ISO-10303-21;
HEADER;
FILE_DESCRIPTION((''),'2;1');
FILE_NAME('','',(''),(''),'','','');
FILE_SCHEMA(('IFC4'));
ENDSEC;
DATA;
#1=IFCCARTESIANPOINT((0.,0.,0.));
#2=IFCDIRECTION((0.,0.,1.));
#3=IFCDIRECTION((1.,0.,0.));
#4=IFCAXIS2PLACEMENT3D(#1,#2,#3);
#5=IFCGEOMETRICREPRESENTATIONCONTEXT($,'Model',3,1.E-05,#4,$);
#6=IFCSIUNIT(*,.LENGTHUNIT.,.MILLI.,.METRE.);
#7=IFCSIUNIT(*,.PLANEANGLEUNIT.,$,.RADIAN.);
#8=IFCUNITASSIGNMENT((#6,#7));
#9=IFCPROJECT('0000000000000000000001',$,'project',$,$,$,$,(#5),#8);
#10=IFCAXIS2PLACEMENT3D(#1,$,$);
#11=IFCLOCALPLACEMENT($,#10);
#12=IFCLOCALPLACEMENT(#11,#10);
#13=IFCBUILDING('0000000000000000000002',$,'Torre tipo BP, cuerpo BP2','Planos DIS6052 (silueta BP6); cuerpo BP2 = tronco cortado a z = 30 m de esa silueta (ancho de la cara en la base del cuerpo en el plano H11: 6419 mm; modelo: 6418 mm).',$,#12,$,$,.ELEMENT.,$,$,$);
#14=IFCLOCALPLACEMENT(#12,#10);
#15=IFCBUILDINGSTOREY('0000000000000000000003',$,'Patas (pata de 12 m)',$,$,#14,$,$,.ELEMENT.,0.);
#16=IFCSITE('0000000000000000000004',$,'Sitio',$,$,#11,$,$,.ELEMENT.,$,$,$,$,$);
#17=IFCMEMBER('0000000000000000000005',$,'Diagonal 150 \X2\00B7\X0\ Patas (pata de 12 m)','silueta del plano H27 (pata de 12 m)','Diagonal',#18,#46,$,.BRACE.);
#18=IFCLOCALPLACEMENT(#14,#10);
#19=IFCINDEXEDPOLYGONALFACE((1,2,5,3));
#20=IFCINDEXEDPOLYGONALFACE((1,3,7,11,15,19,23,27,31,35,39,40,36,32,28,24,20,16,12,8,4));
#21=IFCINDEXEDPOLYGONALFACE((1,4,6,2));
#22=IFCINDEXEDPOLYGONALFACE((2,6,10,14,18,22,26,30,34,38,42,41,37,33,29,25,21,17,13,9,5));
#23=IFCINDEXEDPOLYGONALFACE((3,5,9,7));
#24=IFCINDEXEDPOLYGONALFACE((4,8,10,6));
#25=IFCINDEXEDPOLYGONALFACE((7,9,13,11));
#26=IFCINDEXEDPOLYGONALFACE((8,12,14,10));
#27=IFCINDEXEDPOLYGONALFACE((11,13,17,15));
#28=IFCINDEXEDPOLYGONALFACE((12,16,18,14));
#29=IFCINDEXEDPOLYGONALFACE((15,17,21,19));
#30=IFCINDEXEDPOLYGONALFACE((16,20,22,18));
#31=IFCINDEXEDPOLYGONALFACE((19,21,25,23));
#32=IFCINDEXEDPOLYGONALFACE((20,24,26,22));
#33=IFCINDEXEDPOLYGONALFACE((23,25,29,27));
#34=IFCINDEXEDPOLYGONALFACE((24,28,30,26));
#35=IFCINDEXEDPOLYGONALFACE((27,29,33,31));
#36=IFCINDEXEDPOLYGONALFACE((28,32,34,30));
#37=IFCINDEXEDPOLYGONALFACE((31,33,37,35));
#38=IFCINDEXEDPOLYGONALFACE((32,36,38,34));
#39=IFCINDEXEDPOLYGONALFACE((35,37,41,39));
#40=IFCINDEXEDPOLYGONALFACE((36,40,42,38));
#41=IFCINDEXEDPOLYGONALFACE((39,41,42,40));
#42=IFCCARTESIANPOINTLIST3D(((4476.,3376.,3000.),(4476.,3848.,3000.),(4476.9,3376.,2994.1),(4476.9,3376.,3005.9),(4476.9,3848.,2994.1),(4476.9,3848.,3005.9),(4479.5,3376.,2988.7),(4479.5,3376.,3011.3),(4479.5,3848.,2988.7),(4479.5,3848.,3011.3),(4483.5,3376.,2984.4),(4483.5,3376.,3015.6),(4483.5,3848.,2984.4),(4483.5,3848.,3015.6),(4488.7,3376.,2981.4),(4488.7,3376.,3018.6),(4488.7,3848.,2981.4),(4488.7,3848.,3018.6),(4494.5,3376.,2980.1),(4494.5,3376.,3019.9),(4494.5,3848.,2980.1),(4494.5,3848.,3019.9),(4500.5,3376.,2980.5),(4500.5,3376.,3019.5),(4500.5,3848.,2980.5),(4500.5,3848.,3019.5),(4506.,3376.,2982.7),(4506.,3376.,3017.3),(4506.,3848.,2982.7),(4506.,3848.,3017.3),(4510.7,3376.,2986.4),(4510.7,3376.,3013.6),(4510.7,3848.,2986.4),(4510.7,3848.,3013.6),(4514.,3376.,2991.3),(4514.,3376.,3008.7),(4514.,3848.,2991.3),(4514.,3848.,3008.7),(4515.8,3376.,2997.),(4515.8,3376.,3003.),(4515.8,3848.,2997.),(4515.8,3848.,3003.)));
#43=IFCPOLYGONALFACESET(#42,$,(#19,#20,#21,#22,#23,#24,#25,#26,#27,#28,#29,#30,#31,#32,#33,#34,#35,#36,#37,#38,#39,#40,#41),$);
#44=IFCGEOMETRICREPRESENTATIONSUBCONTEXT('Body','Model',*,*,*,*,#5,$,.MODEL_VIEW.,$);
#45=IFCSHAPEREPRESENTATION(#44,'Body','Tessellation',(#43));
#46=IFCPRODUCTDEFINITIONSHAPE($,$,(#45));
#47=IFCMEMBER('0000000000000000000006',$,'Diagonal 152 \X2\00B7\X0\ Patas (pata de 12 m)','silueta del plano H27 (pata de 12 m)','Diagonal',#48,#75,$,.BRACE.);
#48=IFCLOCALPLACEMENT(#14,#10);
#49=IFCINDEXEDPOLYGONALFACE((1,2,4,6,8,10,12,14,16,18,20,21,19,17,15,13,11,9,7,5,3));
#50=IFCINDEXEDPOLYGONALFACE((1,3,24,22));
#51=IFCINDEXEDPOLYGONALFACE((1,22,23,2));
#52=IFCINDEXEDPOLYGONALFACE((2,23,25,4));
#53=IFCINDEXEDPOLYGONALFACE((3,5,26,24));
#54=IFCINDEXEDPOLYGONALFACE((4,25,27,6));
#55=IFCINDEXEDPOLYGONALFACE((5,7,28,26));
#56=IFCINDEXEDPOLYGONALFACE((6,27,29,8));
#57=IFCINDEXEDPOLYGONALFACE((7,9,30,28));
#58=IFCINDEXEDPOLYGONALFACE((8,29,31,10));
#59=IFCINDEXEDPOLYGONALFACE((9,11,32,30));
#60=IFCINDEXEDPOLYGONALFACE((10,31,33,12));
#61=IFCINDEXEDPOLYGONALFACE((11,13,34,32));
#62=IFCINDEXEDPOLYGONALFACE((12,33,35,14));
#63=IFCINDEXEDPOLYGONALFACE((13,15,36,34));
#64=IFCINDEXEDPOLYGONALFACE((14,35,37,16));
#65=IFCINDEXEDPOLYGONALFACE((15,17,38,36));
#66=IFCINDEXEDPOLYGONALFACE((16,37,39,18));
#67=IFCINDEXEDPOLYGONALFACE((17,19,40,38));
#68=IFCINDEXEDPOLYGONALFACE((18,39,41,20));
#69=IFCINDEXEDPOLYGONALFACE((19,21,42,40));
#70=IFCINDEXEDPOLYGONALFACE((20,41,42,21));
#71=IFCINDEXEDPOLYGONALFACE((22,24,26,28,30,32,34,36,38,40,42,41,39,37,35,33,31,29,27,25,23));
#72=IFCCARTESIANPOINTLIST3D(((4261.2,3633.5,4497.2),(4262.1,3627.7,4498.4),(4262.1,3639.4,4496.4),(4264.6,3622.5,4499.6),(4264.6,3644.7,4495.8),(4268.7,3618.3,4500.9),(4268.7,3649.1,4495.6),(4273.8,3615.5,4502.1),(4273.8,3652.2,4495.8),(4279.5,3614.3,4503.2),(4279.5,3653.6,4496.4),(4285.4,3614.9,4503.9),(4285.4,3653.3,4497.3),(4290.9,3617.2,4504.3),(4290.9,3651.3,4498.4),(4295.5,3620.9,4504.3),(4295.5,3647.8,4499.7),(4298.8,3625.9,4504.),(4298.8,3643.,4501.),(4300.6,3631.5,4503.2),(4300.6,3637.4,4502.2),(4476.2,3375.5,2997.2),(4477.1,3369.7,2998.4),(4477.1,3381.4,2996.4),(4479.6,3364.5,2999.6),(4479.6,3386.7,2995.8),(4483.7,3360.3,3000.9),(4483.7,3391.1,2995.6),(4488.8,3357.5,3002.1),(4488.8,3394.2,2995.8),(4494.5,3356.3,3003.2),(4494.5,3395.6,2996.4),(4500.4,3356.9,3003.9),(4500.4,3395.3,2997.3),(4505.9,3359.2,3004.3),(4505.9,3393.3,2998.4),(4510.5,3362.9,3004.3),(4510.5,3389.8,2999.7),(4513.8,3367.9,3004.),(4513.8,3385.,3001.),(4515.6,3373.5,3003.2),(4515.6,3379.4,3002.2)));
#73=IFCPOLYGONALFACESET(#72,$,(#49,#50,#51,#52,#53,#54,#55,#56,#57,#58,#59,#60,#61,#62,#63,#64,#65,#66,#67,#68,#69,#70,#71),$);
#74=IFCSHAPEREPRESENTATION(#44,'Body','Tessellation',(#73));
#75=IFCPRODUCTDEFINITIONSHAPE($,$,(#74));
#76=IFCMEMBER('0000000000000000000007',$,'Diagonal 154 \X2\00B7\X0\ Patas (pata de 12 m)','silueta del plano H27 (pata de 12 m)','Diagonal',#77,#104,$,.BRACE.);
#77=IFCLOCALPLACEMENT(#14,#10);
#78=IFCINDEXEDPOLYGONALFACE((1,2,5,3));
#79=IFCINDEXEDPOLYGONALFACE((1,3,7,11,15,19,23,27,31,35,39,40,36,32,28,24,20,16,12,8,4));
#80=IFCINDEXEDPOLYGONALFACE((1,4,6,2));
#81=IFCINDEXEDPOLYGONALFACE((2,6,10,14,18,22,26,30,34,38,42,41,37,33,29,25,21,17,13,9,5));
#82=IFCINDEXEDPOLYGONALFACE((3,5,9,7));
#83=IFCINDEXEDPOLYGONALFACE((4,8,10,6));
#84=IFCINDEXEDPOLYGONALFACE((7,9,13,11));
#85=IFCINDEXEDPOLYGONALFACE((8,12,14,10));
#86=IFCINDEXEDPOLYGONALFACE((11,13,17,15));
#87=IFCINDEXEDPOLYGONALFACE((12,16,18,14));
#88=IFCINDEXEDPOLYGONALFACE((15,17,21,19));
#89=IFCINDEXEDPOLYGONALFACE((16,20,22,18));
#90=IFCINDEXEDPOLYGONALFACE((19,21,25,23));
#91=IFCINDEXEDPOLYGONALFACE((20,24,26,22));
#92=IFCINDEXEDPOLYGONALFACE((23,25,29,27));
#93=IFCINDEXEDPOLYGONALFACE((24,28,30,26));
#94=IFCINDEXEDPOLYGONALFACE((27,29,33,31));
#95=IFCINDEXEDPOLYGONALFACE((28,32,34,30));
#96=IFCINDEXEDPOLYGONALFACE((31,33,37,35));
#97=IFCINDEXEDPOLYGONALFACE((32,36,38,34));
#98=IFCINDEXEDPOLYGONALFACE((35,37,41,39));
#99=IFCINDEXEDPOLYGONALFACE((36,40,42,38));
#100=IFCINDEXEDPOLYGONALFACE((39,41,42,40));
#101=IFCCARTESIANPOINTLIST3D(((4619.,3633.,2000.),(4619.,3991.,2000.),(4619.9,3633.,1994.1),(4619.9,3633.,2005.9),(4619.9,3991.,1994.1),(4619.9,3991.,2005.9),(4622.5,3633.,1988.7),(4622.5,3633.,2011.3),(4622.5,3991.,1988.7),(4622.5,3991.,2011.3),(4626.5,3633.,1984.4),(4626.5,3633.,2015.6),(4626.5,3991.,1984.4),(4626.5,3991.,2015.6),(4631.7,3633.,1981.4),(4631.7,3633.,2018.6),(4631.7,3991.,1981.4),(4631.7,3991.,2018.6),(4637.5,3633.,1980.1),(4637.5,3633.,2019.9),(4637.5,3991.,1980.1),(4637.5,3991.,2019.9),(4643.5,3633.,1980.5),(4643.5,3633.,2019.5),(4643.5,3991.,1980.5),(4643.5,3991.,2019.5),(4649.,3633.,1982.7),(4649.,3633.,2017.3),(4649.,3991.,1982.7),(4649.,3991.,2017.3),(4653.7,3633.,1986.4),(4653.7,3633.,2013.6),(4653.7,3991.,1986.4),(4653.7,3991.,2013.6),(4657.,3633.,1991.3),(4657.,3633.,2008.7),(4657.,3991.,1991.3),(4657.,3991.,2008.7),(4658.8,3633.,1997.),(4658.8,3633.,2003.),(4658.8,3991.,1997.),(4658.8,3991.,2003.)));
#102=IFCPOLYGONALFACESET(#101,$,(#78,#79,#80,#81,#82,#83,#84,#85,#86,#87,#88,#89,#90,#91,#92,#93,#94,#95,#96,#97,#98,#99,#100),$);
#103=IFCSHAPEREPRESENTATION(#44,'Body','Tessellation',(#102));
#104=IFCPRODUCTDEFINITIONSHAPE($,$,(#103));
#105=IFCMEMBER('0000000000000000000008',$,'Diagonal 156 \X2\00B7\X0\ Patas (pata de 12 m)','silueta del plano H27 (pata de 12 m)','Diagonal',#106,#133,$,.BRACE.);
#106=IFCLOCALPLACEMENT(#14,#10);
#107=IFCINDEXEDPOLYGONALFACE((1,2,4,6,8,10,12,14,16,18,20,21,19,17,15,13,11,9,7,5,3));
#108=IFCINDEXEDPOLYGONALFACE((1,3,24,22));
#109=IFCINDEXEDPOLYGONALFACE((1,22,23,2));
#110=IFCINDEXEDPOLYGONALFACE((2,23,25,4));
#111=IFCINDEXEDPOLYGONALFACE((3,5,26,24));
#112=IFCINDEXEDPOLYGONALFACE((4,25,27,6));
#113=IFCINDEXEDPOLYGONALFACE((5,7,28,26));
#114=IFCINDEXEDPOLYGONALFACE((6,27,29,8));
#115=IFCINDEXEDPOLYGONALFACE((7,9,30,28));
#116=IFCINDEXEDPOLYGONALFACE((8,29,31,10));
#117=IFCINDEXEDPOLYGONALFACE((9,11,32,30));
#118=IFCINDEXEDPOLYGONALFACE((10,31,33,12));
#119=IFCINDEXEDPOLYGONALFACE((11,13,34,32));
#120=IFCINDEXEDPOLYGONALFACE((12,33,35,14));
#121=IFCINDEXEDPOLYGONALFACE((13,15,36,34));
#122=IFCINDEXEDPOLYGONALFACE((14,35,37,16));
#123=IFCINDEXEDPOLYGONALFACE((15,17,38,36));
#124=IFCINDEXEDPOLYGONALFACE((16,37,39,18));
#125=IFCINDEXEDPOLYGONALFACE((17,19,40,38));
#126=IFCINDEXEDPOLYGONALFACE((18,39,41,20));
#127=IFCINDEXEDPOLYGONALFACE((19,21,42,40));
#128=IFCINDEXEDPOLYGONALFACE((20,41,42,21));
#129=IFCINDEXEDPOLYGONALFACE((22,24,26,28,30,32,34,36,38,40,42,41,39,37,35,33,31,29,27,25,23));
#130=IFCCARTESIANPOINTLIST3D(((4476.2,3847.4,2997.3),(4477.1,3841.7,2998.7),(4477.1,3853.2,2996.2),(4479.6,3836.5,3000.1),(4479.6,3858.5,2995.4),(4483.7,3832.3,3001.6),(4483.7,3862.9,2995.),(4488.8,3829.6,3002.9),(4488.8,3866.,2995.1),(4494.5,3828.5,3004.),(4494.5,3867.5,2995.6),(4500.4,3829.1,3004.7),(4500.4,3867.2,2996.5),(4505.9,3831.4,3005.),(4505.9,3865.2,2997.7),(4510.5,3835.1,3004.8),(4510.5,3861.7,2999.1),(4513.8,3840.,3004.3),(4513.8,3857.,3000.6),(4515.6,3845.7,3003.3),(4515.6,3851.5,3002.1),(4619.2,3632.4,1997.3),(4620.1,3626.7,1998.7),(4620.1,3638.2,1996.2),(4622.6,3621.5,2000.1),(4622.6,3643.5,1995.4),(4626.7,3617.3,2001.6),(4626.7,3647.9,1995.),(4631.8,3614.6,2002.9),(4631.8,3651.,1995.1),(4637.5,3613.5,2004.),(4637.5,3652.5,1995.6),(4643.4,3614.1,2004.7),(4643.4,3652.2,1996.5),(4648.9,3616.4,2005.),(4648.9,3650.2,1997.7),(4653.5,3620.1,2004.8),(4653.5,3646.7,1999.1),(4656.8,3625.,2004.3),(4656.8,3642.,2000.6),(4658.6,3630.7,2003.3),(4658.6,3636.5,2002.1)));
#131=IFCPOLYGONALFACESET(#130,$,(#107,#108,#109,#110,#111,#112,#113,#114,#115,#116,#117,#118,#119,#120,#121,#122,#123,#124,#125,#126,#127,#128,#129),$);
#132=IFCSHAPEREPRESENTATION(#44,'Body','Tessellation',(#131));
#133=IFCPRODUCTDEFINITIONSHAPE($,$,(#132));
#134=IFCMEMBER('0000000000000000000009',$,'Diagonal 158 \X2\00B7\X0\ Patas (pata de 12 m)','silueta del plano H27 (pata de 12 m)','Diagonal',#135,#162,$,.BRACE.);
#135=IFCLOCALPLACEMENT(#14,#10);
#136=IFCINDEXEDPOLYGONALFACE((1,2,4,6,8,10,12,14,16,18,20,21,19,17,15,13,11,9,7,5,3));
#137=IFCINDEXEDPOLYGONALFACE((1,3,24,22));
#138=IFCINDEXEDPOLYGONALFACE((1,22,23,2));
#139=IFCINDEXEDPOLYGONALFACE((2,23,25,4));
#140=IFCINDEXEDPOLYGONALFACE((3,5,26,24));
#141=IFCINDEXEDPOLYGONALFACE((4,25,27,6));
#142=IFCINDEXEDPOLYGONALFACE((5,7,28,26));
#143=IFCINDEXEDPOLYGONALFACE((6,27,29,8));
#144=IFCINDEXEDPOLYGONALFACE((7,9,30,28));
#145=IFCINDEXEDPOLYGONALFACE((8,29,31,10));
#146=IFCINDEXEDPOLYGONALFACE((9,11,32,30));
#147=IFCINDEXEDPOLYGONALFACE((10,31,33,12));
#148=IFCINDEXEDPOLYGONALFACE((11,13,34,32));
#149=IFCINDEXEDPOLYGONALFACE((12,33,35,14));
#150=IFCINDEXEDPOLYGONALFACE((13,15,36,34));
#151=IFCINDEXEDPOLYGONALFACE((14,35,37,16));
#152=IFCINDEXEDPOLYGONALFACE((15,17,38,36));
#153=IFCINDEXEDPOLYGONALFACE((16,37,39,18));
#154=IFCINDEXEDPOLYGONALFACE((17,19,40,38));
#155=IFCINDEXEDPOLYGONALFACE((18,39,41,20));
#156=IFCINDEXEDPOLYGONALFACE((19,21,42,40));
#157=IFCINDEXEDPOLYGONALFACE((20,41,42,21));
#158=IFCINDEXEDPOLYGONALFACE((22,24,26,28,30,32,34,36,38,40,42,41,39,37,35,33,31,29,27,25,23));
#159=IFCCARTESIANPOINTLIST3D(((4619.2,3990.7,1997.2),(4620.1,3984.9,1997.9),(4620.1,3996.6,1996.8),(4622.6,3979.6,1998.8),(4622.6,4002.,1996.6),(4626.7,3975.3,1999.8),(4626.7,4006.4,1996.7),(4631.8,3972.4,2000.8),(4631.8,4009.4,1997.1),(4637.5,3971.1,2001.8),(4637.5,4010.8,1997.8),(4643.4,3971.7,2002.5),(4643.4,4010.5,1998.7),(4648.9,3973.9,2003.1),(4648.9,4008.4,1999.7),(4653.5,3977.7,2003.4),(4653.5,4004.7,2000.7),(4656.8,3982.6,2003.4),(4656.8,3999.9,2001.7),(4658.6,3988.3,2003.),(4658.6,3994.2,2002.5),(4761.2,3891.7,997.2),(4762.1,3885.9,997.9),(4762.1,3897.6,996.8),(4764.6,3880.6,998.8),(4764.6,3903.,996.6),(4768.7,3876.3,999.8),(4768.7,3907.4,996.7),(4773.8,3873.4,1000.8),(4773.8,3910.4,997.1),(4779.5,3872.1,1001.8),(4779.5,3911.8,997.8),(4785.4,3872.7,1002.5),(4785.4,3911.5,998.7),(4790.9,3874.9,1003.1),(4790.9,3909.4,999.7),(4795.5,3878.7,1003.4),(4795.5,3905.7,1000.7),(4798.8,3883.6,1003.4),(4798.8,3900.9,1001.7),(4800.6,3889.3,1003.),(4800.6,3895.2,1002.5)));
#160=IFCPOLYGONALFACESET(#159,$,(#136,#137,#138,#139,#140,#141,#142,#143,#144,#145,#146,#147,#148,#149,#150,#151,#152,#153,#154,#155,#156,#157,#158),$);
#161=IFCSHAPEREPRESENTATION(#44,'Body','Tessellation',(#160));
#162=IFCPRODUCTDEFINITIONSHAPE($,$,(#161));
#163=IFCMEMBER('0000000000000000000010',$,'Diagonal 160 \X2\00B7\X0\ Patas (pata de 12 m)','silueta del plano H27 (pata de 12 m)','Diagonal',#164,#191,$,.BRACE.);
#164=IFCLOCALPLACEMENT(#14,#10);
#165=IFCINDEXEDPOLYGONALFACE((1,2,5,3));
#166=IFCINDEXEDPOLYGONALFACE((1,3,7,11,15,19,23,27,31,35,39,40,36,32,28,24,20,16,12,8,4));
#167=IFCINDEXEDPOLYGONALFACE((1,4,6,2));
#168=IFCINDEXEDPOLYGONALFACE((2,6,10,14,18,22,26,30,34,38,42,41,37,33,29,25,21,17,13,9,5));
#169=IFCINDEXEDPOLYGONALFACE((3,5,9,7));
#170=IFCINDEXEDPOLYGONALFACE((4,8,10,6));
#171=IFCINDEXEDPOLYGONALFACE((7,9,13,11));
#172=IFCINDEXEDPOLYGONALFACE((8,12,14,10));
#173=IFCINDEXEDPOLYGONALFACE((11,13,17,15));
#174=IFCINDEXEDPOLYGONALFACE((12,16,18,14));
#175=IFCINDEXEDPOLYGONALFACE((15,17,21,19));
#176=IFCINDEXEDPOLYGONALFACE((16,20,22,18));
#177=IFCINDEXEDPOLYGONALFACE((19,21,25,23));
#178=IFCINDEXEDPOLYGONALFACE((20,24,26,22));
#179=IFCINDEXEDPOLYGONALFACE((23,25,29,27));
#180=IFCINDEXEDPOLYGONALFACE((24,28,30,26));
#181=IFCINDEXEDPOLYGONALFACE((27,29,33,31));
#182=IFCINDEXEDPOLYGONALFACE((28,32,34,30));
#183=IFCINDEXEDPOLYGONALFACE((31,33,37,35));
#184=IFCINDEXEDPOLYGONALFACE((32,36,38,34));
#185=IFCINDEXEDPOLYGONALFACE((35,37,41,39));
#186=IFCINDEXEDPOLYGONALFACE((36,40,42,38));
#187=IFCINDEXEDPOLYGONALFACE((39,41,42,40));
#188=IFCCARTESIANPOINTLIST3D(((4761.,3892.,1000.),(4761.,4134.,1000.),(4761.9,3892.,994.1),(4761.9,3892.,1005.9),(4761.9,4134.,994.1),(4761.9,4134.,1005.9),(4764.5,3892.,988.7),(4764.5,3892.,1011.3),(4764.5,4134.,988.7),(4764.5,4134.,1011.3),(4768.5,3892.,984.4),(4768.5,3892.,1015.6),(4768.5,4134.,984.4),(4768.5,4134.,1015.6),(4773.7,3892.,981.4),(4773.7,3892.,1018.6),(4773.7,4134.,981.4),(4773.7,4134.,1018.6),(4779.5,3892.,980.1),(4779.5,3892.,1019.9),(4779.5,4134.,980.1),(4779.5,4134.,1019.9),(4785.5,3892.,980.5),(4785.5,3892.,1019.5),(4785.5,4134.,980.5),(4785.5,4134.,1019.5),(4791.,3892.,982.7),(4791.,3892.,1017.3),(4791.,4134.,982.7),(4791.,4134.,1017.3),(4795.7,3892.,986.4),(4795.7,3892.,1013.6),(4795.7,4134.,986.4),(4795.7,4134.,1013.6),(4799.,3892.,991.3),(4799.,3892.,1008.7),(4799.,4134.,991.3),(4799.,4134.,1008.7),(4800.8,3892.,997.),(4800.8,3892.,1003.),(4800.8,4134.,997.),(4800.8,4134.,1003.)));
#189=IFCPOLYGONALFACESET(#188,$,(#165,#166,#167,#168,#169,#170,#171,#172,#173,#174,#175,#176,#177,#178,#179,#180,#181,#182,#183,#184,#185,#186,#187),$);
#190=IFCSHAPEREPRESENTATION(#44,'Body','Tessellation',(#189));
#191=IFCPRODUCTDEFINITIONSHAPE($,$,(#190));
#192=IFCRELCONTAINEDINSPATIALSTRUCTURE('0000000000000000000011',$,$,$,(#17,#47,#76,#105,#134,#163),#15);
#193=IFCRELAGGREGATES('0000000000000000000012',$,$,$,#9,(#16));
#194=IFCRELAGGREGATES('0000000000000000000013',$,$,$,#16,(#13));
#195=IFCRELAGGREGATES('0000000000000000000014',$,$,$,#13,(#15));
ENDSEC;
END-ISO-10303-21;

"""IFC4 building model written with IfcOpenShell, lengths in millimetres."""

from ifc_helpers import new_model, si_unit, frame, origin, origin_with_axes, place, context, subcontext, project, spatial, circle, extrude, element, save


model = new_model("IFC4")

# Units and contexts
model_context = context("Model", 3, precision=1e-05, world=origin_with_axes())
body_context = subcontext(model_context, "Body", "Model", "MODEL_VIEW")
ifc_project = project(units=[si_unit("LENGTHUNIT", "METRE", prefix="MILLI"), si_unit("PLANEANGLEUNIT", "RADIAN")], contexts=[model_context])

# Site, building, storey
site_placement = place(None, origin())
site = spatial("IfcSite", under=ifc_project, at=site_placement, Name="Sitio", CompositionType="ELEMENT")
building_placement = place(site_placement, origin())
building = spatial("IfcBuilding", under=site, at=building_placement, Name="Torre tipo BP, cuerpo BP2", Description="Planos DIS6052 (silueta BP6); cuerpo BP2 = tronco cortado a z = 30 m de esa silueta (ancho de la cara en la base del cuerpo en el plano H11: 6419 mm; modelo: 6418 mm).", CompositionType="ELEMENT")
storey_placement = place(building_placement, origin())
storey = spatial("IfcBuildingStorey", under=building, at=storey_placement, Name="Patas (pata de 12 m)", CompositionType="ELEMENT", Elevation=0.0)

# Members
member_1_placement = place(storey_placement, frame((4496.0, 3848.0, 3000.0), z_axis=(0.0, -1.0, 0.0), x_axis=(-1.0, 0.0, 0.0)))
element("IfcMember", 1, at=member_1_placement, inside=storey, Name="Diagonal 150 · Patas (pata de 12 m)", Description="silueta del plano H27 (pata de 12 m)", ObjectType="Diagonal", PredefinedType="BRACE", context=body_context, shape_type="SweptSolid", body=[
    extrude(circle(Radius=20.0), None, (0.0, 0.0, 1.0), 472.0),
])
member_2_placement = place(storey_placement, frame((4496.0, 3376.0, 3000.0), z_axis=(-0.13987, 0.167845, 0.97584), x_axis=(-0.99017, -0.02371, -0.137846)))
element("IfcMember", 2, at=member_2_placement, inside=storey, Name="Diagonal 152 · Patas (pata de 12 m)", Description="silueta del plano H27 (pata de 12 m)", ObjectType="Diagonal", PredefinedType="BRACE", context=body_context, shape_type="SweptSolid", body=[
    extrude(circle(Radius=20.0), None, (0.0, 0.0, 1.0), 1537.1),
])
member_3_placement = place(storey_placement, frame((4639.0, 3991.0, 2000.0), z_axis=(0.0, -1.0, 0.0), x_axis=(-1.0, 0.0, 0.0)))
element("IfcMember", 3, at=member_3_placement, inside=storey, Name="Diagonal 154 · Patas (pata de 12 m)", Description="silueta del plano H27 (pata de 12 m)", ObjectType="Diagonal", PredefinedType="BRACE", context=body_context, shape_type="SweptSolid", body=[
    extrude(circle(Radius=20.0), None, (0.0, 0.0, 1.0), 358.0),
])
member_4_placement = place(storey_placement, frame((4639.0, 3633.0, 2000.0), z_axis=(-0.138459, 0.208172, 0.968243), x_axis=(-0.990368, -0.029104, -0.135365)))
element("IfcMember", 4, at=member_4_placement, inside=storey, Name="Diagonal 156 · Patas (pata de 12 m)", Description="silueta del plano H27 (pata de 12 m)", ObjectType="Diagonal", PredefinedType="BRACE", context=body_context, shape_type="SweptSolid", body=[
    extrude(circle(Radius=20.0), None, (0.0, 0.0, 1.0), 1032.8),
])
member_5_placement = place(storey_placement, frame((4781.0, 3892.0, 1000.0), z_axis=(-0.139919, 0.097549, 0.985346), x_axis=(-0.990163, -0.013785, -0.139238)))
element("IfcMember", 5, at=member_5_placement, inside=storey, Name="Diagonal 158 · Patas (pata de 12 m)", Description="silueta del plano H27 (pata de 12 m)", ObjectType="Diagonal", PredefinedType="BRACE", context=body_context, shape_type="SweptSolid", body=[
    extrude(circle(Radius=20.0), None, (0.0, 0.0, 1.0), 1014.9),
])
member_6_placement = place(storey_placement, frame((4781.0, 4134.0, 1000.0), z_axis=(0.0, -1.0, 0.0), x_axis=(-1.0, 0.0, 0.0)))
element("IfcMember", 6, at=member_6_placement, inside=storey, Name="Diagonal 160 · Patas (pata de 12 m)", Description="silueta del plano H27 (pata de 12 m)", ObjectType="Diagonal", PredefinedType="BRACE", context=body_context, shape_type="SweptSolid", body=[
    extrude(circle(Radius=20.0), None, (0.0, 0.0, 1.0), 242.0),
])

save(model, "model.ifc")
